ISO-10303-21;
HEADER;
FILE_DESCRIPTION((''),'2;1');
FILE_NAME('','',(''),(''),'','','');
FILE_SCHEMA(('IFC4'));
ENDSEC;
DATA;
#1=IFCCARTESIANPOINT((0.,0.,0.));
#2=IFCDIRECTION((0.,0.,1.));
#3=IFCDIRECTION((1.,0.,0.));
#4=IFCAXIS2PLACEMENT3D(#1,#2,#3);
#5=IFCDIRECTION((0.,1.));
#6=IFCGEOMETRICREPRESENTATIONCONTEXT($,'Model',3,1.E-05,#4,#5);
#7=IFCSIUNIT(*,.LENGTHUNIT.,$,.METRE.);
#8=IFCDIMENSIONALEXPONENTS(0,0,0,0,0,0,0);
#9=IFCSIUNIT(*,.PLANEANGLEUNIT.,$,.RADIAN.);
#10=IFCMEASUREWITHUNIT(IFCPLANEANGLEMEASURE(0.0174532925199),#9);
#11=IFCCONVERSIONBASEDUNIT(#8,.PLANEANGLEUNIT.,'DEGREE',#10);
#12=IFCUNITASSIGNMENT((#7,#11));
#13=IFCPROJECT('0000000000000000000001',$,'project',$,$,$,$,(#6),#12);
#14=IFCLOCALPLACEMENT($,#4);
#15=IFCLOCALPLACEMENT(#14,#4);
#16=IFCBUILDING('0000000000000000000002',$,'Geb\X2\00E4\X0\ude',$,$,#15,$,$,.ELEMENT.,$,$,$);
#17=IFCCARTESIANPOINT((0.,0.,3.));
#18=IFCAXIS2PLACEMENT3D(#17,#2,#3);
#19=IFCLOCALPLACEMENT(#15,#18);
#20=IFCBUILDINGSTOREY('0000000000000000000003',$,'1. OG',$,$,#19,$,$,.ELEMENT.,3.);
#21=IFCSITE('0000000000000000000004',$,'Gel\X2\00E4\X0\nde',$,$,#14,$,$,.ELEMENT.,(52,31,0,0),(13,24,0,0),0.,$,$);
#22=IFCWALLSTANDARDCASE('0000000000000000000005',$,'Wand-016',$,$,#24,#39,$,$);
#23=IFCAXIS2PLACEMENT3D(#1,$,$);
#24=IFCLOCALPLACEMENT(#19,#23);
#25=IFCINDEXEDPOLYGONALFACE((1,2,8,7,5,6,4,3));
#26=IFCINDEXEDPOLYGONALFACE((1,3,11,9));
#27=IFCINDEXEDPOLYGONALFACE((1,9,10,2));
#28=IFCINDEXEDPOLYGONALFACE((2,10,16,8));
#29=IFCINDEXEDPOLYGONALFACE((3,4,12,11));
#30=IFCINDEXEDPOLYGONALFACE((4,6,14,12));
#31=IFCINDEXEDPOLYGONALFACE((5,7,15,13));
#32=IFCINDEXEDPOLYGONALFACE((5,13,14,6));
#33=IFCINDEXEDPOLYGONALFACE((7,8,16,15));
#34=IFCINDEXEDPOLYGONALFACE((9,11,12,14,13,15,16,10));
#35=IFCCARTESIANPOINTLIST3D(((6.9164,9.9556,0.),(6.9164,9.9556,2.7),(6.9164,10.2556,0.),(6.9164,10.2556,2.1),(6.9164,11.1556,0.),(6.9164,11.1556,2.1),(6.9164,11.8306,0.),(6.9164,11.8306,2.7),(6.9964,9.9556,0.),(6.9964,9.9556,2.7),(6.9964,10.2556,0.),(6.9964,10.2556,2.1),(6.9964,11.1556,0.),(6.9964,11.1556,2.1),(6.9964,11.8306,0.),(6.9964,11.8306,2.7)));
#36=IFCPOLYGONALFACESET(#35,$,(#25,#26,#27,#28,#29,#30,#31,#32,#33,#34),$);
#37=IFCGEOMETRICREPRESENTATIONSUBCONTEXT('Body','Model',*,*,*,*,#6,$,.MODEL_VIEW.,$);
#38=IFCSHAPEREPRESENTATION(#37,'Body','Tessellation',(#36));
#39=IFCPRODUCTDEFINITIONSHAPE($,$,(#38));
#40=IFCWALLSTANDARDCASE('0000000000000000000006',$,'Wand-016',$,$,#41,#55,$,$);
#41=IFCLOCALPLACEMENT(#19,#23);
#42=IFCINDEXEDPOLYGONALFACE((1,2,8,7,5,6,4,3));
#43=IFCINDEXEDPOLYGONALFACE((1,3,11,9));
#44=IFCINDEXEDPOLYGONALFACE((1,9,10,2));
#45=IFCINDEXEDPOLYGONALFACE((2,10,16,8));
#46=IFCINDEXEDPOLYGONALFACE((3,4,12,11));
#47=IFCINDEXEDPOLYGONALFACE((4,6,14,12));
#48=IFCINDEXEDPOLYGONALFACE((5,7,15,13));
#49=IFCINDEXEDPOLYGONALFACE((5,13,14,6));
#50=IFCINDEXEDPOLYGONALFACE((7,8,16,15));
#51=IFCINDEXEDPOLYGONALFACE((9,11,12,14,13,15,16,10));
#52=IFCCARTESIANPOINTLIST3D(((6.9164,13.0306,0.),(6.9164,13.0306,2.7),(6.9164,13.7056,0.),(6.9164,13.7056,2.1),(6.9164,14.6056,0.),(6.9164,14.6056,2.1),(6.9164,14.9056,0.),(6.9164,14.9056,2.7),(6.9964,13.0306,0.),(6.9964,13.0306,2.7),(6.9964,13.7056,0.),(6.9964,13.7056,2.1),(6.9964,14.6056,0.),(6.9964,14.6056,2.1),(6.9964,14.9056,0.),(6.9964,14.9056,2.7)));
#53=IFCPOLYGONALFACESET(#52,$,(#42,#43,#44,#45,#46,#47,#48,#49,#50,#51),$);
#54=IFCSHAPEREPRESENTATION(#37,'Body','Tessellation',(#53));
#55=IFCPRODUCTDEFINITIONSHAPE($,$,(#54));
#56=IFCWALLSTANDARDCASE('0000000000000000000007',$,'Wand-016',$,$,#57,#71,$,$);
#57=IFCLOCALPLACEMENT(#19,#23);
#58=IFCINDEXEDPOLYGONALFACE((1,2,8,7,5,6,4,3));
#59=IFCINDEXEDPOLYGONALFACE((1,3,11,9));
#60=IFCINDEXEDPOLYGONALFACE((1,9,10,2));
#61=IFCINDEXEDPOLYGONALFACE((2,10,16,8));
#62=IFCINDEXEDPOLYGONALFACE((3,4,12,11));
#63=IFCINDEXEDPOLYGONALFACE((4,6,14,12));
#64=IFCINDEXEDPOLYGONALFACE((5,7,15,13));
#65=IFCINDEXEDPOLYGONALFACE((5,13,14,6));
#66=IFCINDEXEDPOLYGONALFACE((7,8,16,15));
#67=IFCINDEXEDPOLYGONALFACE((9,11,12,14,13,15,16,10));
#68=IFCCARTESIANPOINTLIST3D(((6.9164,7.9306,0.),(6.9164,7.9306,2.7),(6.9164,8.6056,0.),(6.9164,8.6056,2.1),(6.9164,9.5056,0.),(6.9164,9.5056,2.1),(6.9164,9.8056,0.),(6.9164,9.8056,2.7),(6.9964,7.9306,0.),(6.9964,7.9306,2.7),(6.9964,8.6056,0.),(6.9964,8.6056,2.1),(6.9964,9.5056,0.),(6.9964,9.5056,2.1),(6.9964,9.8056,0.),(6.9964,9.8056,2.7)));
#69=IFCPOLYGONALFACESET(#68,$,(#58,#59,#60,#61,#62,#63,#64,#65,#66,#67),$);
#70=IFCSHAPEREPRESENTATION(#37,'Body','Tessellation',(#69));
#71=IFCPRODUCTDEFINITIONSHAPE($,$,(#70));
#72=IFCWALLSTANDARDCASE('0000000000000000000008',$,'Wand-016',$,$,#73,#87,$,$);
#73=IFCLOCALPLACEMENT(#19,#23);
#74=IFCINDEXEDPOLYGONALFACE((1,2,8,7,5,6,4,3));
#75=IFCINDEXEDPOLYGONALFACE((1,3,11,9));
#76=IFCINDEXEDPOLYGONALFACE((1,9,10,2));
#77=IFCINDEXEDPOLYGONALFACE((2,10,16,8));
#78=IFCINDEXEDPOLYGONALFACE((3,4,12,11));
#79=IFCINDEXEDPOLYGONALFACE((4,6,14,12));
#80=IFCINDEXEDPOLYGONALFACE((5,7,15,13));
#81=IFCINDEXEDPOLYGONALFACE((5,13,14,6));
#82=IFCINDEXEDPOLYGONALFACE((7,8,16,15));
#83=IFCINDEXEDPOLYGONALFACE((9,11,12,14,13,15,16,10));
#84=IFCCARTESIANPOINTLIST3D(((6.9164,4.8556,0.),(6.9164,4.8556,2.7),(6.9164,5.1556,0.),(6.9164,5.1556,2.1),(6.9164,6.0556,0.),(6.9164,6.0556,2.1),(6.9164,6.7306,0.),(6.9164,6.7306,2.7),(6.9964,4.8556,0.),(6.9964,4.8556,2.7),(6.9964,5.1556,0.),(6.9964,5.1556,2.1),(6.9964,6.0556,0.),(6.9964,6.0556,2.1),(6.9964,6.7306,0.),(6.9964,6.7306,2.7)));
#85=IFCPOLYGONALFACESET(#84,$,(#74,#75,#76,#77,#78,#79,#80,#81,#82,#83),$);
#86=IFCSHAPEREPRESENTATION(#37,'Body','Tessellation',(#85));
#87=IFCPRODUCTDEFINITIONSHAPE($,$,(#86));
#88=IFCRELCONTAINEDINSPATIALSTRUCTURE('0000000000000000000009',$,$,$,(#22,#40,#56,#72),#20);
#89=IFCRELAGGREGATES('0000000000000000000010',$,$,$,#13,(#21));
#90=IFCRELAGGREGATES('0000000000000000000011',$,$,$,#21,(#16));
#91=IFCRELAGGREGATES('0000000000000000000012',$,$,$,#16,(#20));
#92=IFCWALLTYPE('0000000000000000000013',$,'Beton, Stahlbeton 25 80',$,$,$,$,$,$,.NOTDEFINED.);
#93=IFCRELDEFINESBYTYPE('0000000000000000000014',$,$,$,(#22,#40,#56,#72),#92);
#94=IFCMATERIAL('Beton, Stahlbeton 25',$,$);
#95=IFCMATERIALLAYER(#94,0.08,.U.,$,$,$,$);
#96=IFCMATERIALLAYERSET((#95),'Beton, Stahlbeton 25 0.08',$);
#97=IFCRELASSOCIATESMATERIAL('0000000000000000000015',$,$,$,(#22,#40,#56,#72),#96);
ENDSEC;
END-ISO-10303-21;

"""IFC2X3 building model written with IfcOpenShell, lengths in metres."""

from ifc_helpers import new_model, entity, si_unit, converted_unit, direction, frame, origin_with_axes, origin_2d_with_axis, place, context, subcontext, project, spatial, polyline, rectangle, outline, extrude, material, layer, layer_set, layer_usage, type_object, element, save


model = new_model("IFC2X3")

# Units and contexts
model_context = context("Model", 3, precision=1e-05, world=origin_with_axes(), true_north=direction((0.0, 1.0)))
body_context = subcontext(model_context, "Body", "Model", "MODEL_VIEW")
ifc_project = project(units=[si_unit("LENGTHUNIT", "METRE"), converted_unit("PLANEANGLEUNIT", "DEGREE", entity("IfcPlaneAngleMeasure", 0.0174532925199), si_unit("PLANEANGLEUNIT", "RADIAN"), dimensions=[0, 0, 0, 0, 0, 0, 0])], contexts=[model_context])

# Site, building, storey
site_placement = place(None, origin_with_axes())
site = spatial("IfcSite", under=ifc_project, at=site_placement, Name="Gelände", CompositionType="ELEMENT", RefLatitude=(52, 31, 0, 0), RefLongitude=(13, 24, 0, 0), RefElevation=0.0)
building_placement = place(site_placement, origin_with_axes())
building = spatial("IfcBuilding", under=site, at=building_placement, Name="Gebäude", CompositionType="ELEMENT")
storey_placement = place(building_placement, frame((0.0, 0.0, 3.0), z_axis=(0.0, 0.0, 1.0), x_axis=(1.0, 0.0, 0.0)))
storey = spatial("IfcBuildingStorey", under=building, at=storey_placement, Name="1. OG", CompositionType="ELEMENT", Elevation=3.0)

# Shared definitions
ifc_material = material(Name="Beton, Stahlbeton 25")

# Walls, openings
ifc_layer_1 = layer(ifc_material, 0.08, ventilated="UNKNOWN")
ifc_layer_set_1 = layer_set([ifc_layer_1], Name="Beton, Stahlbeton 25 0.08")
wall_type_1 = type_object("IfcWallType", Name="Beton, Stahlbeton 25 80", PredefinedType="NOTDEFINED")
ifc_layer_usage_1 = layer_usage(ifc_layer_set_1, "AXIS2", "POSITIVE", 0.0)
wall_1_placement = place(storey_placement, frame((6.9164, 11.8306, 0.0), z_axis=(0.0, 0.0, 1.0), x_axis=(0.0, -1.0, 0.0)))
wall_1 = element("IfcWallStandardCase", 1, at=wall_1_placement, inside=storey, type_object=wall_type_1, material=ifc_layer_usage_1, Name="Wand-016", context=body_context, shape_type="SweptSolid", body=[
    extrude(outline(polyline([(0.0, 0.0), (1.875, 0.0), (1.875, 0.08), (0.0, 0.08), (0.0, 0.0)])), origin_with_axes(), (0.0, 0.0, 1.0), 2.7),
])
opening_1_placement = place(wall_1_placement, frame((1.125, 0.0, 0.0), z_axis=(0.0, 0.0, 1.0), x_axis=(1.0, 0.0, 0.0)))
element("IfcOpeningElement", 2, at=opening_1_placement, cuts=wall_1, context=body_context, shape_type="SweptSolid", body=[
    extrude(rectangle(XDim=0.9, YDim=2.1, at=origin_2d_with_axis()), frame((0.0, -0.08, 1.05), z_axis=(0.0, 1.0, 0.0), x_axis=(1.0, 0.0, 0.0)), (0.0, 0.0, 1.0), 0.08),
    extrude(rectangle(XDim=0.9, YDim=2.1, at=origin_2d_with_axis()), frame((0.0, 0.08, 1.05), z_axis=(0.0, -1.0, 0.0), x_axis=(1.0, 0.0, 0.0)), (0.0, 0.0, 1.0), 0.08),
])
ifc_layer_usage_2 = layer_usage(ifc_layer_set_1, "AXIS2", "NEGATIVE", 0.0)
wall_2_placement = place(storey_placement, frame((6.9164, 13.0306, 0.0), z_axis=(0.0, 0.0, 1.0), x_axis=(0.0, 1.0, 0.0)))
wall_2 = element("IfcWallStandardCase", 3, at=wall_2_placement, inside=storey, type_object=wall_type_1, material=ifc_layer_usage_2, Name="Wand-016", context=body_context, shape_type="SweptSolid", body=[
    extrude(outline(polyline([(0.0, -0.08), (1.875, -0.08), (1.875, 0.0), (0.0, 0.0), (0.0, -0.08)])), origin_with_axes(), (0.0, 0.0, 1.0), 2.7),
])
opening_2_placement = place(wall_2_placement, frame((1.125, 0.0, 0.0), z_axis=(0.0, 0.0, 1.0), x_axis=(1.0, 0.0, 0.0)))
element("IfcOpeningElement", 4, at=opening_2_placement, cuts=wall_2, context=body_context, shape_type="SweptSolid", body=[
    extrude(rectangle(XDim=0.9, YDim=2.1, at=origin_2d_with_axis()), frame((0.0, 0.08, 1.05), z_axis=(0.0, -1.0, 0.0), x_axis=(1.0, 0.0, 0.0)), (0.0, 0.0, 1.0), 0.08),
    extrude(rectangle(XDim=0.9, YDim=2.1, at=origin_2d_with_axis()), frame((0.0, -0.08, 1.05), z_axis=(0.0, 1.0, 0.0), x_axis=(1.0, 0.0, 0.0)), (0.0, 0.0, 1.0), 0.08),
])
ifc_layer_usage_3 = layer_usage(ifc_layer_set_1, "AXIS2", "NEGATIVE", 0.0)
wall_3_placement = place(storey_placement, frame((6.9164, 7.9306, 0.0), z_axis=(0.0, 0.0, 1.0), x_axis=(0.0, 1.0, 0.0)))
wall_3 = element("IfcWallStandardCase", 5, at=wall_3_placement, inside=storey, type_object=wall_type_1, material=ifc_layer_usage_3, Name="Wand-016", context=body_context, shape_type="SweptSolid", body=[
    extrude(outline(polyline([(0.0, -0.08), (1.875, -0.08), (1.875, 0.0), (0.0, 0.0), (0.0, -0.08)])), origin_with_axes(), (0.0, 0.0, 1.0), 2.7),
])
opening_3_placement = place(wall_3_placement, frame((1.125, 0.0, 0.0), z_axis=(0.0, 0.0, 1.0), x_axis=(1.0, 0.0, 0.0)))
element("IfcOpeningElement", 6, at=opening_3_placement, cuts=wall_3, context=body_context, shape_type="SweptSolid", body=[
    extrude(rectangle(XDim=0.9, YDim=2.1, at=origin_2d_with_axis()), frame((0.0, 0.08, 1.05), z_axis=(0.0, -1.0, 0.0), x_axis=(1.0, 0.0, 0.0)), (0.0, 0.0, 1.0), 0.08),
    extrude(rectangle(XDim=0.9, YDim=2.1, at=origin_2d_with_axis()), frame((0.0, -0.08, 1.05), z_axis=(0.0, 1.0, 0.0), x_axis=(1.0, 0.0, 0.0)), (0.0, 0.0, 1.0), 0.08),
])
ifc_layer_usage_4 = layer_usage(ifc_layer_set_1, "AXIS2", "POSITIVE", 0.0)
wall_4_placement = place(storey_placement, frame((6.9164, 6.7306, 0.0), z_axis=(0.0, 0.0, 1.0), x_axis=(0.0, -1.0, 0.0)))
wall_4 = element("IfcWallStandardCase", 7, at=wall_4_placement, inside=storey, type_object=wall_type_1, material=ifc_layer_usage_4, Name="Wand-016", context=body_context, shape_type="SweptSolid", body=[
    extrude(outline(polyline([(0.0, 0.0), (1.875, 0.0), (1.875, 0.08), (0.0, 0.08), (0.0, 0.0)])), origin_with_axes(), (0.0, 0.0, 1.0), 2.7),
])
opening_4_placement = place(wall_4_placement, frame((1.125, 0.0, 0.0), z_axis=(0.0, 0.0, 1.0), x_axis=(1.0, 0.0, 0.0)))
element("IfcOpeningElement", 8, at=opening_4_placement, cuts=wall_4, context=body_context, shape_type="SweptSolid", body=[
    extrude(rectangle(XDim=0.9, YDim=2.1, at=origin_2d_with_axis()), frame((0.0, -0.08, 1.05), z_axis=(0.0, 1.0, 0.0), x_axis=(1.0, 0.0, 0.0)), (0.0, 0.0, 1.0), 0.08),
    extrude(rectangle(XDim=0.9, YDim=2.1, at=origin_2d_with_axis()), frame((0.0, 0.08, 1.05), z_axis=(0.0, -1.0, 0.0), x_axis=(1.0, 0.0, 0.0)), (0.0, 0.0, 1.0), 0.08),
])

save(model, "model.ifc")
